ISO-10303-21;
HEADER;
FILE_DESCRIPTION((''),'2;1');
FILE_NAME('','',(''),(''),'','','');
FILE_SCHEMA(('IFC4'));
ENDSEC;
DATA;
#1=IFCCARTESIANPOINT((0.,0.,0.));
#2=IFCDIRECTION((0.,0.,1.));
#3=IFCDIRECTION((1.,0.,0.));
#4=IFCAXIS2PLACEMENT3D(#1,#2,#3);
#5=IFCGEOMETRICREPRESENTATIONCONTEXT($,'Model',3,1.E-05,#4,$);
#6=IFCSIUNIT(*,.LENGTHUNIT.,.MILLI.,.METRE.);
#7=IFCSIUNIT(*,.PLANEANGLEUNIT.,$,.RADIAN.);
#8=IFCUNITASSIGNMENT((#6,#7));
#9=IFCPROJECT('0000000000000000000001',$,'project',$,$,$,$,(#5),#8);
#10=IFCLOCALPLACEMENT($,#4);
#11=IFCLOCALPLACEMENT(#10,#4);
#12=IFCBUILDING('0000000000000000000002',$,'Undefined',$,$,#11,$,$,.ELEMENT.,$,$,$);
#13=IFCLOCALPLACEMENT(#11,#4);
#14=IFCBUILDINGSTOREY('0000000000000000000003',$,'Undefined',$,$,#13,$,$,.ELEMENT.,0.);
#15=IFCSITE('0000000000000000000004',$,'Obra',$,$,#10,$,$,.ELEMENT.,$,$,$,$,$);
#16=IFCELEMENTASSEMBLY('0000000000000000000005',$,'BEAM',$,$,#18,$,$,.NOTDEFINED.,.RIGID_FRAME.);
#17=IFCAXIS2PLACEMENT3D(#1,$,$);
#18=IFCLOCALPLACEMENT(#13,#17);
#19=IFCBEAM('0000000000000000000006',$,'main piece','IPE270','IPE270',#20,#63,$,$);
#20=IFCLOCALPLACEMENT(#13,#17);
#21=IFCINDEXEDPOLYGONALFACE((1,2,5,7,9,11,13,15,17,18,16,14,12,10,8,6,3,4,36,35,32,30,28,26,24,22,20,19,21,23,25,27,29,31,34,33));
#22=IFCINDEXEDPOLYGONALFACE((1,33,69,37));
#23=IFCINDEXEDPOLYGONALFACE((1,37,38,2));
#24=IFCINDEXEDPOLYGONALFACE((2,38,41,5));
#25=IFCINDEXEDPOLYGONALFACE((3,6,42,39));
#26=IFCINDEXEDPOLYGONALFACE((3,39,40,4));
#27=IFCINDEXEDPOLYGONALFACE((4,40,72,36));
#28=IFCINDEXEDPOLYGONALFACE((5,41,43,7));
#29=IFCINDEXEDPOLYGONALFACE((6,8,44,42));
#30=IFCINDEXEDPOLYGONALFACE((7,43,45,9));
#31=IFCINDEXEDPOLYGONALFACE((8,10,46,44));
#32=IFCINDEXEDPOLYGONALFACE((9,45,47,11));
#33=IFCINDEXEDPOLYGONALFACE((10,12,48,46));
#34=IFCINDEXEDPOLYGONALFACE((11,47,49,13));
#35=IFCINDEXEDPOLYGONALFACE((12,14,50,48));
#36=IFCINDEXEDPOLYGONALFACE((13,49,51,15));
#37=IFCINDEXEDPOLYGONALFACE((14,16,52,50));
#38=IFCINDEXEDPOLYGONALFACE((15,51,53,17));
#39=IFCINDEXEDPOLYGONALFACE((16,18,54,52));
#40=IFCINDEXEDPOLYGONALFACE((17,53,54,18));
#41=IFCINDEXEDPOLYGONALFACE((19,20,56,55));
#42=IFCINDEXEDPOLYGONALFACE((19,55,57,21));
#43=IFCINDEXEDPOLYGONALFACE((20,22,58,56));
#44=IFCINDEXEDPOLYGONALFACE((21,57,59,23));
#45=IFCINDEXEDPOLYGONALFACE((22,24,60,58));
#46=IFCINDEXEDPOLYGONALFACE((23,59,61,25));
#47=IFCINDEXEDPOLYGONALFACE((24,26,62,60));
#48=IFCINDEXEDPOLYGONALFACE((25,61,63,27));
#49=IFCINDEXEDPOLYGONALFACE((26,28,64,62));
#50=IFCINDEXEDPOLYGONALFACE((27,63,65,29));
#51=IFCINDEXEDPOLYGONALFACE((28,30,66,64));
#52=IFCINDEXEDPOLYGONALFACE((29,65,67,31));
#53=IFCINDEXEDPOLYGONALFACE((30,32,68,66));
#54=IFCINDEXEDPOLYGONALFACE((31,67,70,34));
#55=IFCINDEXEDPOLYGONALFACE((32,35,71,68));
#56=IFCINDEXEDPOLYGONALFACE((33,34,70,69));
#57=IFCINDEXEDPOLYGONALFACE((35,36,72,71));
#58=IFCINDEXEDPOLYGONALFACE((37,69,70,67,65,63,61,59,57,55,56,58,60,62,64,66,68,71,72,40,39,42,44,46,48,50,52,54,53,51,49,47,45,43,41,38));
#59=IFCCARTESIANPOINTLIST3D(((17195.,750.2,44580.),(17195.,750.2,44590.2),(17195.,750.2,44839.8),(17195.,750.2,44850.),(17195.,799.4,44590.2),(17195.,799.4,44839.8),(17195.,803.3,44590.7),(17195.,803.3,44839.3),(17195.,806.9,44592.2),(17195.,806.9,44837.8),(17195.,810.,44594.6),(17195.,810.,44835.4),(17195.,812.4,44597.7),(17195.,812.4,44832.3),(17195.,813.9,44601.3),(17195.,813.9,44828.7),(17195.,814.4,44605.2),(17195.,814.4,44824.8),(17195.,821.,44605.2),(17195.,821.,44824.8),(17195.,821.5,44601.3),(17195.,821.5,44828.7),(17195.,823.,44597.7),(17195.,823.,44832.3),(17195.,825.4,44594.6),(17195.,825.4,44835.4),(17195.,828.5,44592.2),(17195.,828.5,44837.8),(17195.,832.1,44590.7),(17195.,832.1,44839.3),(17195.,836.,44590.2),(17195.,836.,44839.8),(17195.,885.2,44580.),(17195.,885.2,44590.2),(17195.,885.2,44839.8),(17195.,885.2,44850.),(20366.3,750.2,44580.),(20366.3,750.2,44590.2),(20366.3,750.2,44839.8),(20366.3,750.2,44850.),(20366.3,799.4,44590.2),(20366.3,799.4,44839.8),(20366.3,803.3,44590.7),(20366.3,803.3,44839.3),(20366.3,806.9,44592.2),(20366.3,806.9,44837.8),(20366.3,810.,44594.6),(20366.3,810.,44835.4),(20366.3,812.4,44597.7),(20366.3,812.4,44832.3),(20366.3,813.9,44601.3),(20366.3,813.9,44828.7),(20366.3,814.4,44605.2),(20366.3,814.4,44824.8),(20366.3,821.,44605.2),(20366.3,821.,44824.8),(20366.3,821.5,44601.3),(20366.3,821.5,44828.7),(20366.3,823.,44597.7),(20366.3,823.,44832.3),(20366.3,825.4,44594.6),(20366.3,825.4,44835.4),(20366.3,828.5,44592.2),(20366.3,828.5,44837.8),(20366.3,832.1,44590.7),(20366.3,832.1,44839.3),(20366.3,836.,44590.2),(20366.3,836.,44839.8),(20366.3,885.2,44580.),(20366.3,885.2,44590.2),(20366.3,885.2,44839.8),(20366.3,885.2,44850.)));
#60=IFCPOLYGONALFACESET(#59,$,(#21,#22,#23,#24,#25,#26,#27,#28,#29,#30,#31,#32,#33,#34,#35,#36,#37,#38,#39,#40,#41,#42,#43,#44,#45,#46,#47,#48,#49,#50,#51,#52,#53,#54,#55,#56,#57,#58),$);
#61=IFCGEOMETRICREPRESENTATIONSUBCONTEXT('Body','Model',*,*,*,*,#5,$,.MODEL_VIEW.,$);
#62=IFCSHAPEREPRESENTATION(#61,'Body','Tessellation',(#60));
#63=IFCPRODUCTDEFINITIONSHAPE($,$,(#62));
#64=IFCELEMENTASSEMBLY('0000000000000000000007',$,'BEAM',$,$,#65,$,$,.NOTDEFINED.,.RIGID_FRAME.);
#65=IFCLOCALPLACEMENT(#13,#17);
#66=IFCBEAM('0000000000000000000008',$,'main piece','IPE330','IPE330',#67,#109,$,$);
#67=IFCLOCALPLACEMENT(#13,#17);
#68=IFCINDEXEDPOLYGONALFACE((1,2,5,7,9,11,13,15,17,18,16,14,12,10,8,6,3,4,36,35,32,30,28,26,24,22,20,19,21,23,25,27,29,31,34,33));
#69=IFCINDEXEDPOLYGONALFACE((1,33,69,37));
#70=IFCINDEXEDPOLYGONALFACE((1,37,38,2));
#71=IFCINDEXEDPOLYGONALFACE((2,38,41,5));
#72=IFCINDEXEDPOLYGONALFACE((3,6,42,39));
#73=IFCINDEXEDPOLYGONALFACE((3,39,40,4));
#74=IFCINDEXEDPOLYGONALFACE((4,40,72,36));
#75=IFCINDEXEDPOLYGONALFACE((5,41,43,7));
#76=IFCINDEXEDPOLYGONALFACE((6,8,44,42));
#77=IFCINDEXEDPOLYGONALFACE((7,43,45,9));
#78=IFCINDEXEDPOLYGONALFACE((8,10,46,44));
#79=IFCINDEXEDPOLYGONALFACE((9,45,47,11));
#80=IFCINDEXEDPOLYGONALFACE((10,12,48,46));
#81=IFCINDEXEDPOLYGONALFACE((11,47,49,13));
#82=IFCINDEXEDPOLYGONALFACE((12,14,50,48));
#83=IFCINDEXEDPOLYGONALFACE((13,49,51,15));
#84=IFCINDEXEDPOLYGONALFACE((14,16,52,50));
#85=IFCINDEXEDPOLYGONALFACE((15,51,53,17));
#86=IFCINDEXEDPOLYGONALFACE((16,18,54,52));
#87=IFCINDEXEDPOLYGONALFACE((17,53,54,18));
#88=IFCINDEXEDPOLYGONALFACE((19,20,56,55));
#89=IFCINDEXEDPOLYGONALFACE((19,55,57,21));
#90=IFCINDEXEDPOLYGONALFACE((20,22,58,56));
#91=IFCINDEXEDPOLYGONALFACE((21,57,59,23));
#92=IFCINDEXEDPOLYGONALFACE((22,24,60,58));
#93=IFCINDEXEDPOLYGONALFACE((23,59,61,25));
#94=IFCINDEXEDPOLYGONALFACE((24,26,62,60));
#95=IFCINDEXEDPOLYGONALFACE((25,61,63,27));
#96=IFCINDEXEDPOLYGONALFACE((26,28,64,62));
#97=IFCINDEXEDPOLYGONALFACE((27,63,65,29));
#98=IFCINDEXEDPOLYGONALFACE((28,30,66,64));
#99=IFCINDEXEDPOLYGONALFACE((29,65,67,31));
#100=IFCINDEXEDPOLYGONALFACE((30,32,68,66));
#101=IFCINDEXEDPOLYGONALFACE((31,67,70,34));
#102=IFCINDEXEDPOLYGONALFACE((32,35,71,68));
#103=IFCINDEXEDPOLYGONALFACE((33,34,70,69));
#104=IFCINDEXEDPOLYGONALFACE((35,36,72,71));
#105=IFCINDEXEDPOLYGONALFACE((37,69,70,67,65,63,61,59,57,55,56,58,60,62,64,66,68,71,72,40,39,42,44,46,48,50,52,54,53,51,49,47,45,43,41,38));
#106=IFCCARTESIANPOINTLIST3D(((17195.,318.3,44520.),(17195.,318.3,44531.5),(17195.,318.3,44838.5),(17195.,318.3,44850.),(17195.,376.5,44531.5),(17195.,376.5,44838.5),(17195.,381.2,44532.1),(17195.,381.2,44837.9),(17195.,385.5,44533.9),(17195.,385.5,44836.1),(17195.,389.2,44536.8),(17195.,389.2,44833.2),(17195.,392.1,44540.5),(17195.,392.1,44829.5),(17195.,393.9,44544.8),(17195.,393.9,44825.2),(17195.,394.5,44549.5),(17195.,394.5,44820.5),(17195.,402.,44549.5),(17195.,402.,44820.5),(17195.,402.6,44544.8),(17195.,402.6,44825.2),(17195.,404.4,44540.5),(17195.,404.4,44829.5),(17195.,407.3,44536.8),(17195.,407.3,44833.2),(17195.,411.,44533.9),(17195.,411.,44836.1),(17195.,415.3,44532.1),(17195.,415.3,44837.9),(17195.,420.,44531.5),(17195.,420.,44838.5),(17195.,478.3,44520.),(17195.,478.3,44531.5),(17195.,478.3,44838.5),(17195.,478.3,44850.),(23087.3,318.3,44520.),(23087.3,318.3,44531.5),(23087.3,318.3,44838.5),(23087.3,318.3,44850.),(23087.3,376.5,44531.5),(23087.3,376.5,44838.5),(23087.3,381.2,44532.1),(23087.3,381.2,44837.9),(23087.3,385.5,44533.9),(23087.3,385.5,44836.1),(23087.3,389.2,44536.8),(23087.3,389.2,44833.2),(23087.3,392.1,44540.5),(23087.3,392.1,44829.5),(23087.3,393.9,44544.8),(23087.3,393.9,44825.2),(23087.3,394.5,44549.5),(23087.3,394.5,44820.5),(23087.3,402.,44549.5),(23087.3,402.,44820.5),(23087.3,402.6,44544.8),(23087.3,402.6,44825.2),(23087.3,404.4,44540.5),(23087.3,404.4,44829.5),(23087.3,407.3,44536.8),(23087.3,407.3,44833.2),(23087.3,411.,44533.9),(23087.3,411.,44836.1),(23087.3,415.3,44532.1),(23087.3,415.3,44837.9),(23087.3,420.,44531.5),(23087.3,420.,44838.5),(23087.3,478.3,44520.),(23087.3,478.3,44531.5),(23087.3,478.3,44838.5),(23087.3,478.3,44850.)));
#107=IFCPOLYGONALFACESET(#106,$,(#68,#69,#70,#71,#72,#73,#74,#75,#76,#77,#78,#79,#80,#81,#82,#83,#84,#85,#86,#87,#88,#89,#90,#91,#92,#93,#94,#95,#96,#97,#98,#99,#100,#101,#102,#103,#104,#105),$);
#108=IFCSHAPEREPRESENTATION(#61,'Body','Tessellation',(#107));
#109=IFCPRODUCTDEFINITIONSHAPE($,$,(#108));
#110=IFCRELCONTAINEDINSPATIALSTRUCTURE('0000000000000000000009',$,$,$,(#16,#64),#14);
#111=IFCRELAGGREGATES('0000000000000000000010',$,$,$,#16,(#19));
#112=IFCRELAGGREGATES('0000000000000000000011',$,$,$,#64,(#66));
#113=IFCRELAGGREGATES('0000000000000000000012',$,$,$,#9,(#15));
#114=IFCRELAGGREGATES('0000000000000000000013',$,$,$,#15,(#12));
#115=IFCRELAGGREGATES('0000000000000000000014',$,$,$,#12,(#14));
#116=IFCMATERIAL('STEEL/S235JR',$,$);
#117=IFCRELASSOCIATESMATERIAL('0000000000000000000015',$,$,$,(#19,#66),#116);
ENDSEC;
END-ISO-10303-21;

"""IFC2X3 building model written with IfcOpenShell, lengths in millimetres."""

from ifc_helpers import new_model, si_unit, frame, origin_with_axes, origin_2d_with_axis, place, context, subcontext, project, spatial, i_section, extrude, material, element, aggregate, save


model = new_model("IFC2X3")

# Units and contexts
model_context = context("Model", 3, precision=1e-05, world=origin_with_axes())
body_context = subcontext(model_context, "Body", "Model", "MODEL_VIEW")
ifc_project = project(units=[si_unit("LENGTHUNIT", "METRE", prefix="MILLI"), si_unit("PLANEANGLEUNIT", "RADIAN")], contexts=[model_context])

# Site, building, storey
site_placement = place(None, origin_with_axes())
site = spatial("IfcSite", under=ifc_project, at=site_placement, Name="Obra", CompositionType="ELEMENT")
building_placement = place(site_placement, origin_with_axes())
building = spatial("IfcBuilding", under=site, at=building_placement, Name="Undefined", CompositionType="ELEMENT")
storey_placement = place(building_placement, origin_with_axes())
storey = spatial("IfcBuildingStorey", under=building, at=storey_placement, Name="Undefined", CompositionType="ELEMENT", Elevation=0.0)

# Shared definitions
ifc_material = material(Name="STEEL/S235JR")

# Element assemblies, beams
assembly_1_placement = place(storey_placement, origin_with_axes())
assembly_1 = element("IfcElementAssembly", 1, at=assembly_1_placement, inside=storey, Name="BEAM", AssemblyPlace="NOTDEFINED", PredefinedType="RIGID_FRAME")
beam_1_placement = place(assembly_1_placement, frame((17195.0, 817.7, 44715.0), z_axis=(0.0, 0.0, 1.0), x_axis=(1.0, 0.0, 0.0)))
beam_1 = element("IfcBeam", 2, at=beam_1_placement, material=ifc_material, Name="main piece", Description="IPE270", ObjectType="IPE270", context=body_context, shape_type="SweptSolid", body=[
    extrude(i_section(OverallWidth=135.0, OverallDepth=270.0, WebThickness=6.6, FlangeThickness=10.2, FilletRadius=15.0, at=origin_2d_with_axis()), frame((3171.3, 0.0, 0.0), z_axis=(-1.0, 0.0, 0.0), x_axis=(0.0, -1.0, 0.0)), (0.0, 0.0, 1.0), 3171.3),
])
aggregate(assembly_1, [beam_1])
assembly_2_placement = place(storey_placement, origin_with_axes())
assembly_2 = element("IfcElementAssembly", 3, at=assembly_2_placement, inside=storey, Name="BEAM", AssemblyPlace="NOTDEFINED", PredefinedType="RIGID_FRAME")
beam_2_placement = place(assembly_2_placement, frame((17195.0, 398.3, 44685.0), z_axis=(0.0, 0.0, 1.0), x_axis=(1.0, 0.0, 0.0)))
beam_2 = element("IfcBeam", 4, at=beam_2_placement, material=ifc_material, Name="main piece", Description="IPE330", ObjectType="IPE330", context=body_context, shape_type="SweptSolid", body=[
    extrude(i_section(OverallWidth=160.0, OverallDepth=330.0, WebThickness=7.5, FlangeThickness=11.5, FilletRadius=18.0, at=origin_2d_with_axis()), frame((5892.3, 0.0, 0.0), z_axis=(-1.0, 0.0, 0.0), x_axis=(0.0, -1.0, 0.0)), (0.0, 0.0, 1.0), 5892.3),
])
aggregate(assembly_2, [beam_2])

save(model, "model.ifc")
